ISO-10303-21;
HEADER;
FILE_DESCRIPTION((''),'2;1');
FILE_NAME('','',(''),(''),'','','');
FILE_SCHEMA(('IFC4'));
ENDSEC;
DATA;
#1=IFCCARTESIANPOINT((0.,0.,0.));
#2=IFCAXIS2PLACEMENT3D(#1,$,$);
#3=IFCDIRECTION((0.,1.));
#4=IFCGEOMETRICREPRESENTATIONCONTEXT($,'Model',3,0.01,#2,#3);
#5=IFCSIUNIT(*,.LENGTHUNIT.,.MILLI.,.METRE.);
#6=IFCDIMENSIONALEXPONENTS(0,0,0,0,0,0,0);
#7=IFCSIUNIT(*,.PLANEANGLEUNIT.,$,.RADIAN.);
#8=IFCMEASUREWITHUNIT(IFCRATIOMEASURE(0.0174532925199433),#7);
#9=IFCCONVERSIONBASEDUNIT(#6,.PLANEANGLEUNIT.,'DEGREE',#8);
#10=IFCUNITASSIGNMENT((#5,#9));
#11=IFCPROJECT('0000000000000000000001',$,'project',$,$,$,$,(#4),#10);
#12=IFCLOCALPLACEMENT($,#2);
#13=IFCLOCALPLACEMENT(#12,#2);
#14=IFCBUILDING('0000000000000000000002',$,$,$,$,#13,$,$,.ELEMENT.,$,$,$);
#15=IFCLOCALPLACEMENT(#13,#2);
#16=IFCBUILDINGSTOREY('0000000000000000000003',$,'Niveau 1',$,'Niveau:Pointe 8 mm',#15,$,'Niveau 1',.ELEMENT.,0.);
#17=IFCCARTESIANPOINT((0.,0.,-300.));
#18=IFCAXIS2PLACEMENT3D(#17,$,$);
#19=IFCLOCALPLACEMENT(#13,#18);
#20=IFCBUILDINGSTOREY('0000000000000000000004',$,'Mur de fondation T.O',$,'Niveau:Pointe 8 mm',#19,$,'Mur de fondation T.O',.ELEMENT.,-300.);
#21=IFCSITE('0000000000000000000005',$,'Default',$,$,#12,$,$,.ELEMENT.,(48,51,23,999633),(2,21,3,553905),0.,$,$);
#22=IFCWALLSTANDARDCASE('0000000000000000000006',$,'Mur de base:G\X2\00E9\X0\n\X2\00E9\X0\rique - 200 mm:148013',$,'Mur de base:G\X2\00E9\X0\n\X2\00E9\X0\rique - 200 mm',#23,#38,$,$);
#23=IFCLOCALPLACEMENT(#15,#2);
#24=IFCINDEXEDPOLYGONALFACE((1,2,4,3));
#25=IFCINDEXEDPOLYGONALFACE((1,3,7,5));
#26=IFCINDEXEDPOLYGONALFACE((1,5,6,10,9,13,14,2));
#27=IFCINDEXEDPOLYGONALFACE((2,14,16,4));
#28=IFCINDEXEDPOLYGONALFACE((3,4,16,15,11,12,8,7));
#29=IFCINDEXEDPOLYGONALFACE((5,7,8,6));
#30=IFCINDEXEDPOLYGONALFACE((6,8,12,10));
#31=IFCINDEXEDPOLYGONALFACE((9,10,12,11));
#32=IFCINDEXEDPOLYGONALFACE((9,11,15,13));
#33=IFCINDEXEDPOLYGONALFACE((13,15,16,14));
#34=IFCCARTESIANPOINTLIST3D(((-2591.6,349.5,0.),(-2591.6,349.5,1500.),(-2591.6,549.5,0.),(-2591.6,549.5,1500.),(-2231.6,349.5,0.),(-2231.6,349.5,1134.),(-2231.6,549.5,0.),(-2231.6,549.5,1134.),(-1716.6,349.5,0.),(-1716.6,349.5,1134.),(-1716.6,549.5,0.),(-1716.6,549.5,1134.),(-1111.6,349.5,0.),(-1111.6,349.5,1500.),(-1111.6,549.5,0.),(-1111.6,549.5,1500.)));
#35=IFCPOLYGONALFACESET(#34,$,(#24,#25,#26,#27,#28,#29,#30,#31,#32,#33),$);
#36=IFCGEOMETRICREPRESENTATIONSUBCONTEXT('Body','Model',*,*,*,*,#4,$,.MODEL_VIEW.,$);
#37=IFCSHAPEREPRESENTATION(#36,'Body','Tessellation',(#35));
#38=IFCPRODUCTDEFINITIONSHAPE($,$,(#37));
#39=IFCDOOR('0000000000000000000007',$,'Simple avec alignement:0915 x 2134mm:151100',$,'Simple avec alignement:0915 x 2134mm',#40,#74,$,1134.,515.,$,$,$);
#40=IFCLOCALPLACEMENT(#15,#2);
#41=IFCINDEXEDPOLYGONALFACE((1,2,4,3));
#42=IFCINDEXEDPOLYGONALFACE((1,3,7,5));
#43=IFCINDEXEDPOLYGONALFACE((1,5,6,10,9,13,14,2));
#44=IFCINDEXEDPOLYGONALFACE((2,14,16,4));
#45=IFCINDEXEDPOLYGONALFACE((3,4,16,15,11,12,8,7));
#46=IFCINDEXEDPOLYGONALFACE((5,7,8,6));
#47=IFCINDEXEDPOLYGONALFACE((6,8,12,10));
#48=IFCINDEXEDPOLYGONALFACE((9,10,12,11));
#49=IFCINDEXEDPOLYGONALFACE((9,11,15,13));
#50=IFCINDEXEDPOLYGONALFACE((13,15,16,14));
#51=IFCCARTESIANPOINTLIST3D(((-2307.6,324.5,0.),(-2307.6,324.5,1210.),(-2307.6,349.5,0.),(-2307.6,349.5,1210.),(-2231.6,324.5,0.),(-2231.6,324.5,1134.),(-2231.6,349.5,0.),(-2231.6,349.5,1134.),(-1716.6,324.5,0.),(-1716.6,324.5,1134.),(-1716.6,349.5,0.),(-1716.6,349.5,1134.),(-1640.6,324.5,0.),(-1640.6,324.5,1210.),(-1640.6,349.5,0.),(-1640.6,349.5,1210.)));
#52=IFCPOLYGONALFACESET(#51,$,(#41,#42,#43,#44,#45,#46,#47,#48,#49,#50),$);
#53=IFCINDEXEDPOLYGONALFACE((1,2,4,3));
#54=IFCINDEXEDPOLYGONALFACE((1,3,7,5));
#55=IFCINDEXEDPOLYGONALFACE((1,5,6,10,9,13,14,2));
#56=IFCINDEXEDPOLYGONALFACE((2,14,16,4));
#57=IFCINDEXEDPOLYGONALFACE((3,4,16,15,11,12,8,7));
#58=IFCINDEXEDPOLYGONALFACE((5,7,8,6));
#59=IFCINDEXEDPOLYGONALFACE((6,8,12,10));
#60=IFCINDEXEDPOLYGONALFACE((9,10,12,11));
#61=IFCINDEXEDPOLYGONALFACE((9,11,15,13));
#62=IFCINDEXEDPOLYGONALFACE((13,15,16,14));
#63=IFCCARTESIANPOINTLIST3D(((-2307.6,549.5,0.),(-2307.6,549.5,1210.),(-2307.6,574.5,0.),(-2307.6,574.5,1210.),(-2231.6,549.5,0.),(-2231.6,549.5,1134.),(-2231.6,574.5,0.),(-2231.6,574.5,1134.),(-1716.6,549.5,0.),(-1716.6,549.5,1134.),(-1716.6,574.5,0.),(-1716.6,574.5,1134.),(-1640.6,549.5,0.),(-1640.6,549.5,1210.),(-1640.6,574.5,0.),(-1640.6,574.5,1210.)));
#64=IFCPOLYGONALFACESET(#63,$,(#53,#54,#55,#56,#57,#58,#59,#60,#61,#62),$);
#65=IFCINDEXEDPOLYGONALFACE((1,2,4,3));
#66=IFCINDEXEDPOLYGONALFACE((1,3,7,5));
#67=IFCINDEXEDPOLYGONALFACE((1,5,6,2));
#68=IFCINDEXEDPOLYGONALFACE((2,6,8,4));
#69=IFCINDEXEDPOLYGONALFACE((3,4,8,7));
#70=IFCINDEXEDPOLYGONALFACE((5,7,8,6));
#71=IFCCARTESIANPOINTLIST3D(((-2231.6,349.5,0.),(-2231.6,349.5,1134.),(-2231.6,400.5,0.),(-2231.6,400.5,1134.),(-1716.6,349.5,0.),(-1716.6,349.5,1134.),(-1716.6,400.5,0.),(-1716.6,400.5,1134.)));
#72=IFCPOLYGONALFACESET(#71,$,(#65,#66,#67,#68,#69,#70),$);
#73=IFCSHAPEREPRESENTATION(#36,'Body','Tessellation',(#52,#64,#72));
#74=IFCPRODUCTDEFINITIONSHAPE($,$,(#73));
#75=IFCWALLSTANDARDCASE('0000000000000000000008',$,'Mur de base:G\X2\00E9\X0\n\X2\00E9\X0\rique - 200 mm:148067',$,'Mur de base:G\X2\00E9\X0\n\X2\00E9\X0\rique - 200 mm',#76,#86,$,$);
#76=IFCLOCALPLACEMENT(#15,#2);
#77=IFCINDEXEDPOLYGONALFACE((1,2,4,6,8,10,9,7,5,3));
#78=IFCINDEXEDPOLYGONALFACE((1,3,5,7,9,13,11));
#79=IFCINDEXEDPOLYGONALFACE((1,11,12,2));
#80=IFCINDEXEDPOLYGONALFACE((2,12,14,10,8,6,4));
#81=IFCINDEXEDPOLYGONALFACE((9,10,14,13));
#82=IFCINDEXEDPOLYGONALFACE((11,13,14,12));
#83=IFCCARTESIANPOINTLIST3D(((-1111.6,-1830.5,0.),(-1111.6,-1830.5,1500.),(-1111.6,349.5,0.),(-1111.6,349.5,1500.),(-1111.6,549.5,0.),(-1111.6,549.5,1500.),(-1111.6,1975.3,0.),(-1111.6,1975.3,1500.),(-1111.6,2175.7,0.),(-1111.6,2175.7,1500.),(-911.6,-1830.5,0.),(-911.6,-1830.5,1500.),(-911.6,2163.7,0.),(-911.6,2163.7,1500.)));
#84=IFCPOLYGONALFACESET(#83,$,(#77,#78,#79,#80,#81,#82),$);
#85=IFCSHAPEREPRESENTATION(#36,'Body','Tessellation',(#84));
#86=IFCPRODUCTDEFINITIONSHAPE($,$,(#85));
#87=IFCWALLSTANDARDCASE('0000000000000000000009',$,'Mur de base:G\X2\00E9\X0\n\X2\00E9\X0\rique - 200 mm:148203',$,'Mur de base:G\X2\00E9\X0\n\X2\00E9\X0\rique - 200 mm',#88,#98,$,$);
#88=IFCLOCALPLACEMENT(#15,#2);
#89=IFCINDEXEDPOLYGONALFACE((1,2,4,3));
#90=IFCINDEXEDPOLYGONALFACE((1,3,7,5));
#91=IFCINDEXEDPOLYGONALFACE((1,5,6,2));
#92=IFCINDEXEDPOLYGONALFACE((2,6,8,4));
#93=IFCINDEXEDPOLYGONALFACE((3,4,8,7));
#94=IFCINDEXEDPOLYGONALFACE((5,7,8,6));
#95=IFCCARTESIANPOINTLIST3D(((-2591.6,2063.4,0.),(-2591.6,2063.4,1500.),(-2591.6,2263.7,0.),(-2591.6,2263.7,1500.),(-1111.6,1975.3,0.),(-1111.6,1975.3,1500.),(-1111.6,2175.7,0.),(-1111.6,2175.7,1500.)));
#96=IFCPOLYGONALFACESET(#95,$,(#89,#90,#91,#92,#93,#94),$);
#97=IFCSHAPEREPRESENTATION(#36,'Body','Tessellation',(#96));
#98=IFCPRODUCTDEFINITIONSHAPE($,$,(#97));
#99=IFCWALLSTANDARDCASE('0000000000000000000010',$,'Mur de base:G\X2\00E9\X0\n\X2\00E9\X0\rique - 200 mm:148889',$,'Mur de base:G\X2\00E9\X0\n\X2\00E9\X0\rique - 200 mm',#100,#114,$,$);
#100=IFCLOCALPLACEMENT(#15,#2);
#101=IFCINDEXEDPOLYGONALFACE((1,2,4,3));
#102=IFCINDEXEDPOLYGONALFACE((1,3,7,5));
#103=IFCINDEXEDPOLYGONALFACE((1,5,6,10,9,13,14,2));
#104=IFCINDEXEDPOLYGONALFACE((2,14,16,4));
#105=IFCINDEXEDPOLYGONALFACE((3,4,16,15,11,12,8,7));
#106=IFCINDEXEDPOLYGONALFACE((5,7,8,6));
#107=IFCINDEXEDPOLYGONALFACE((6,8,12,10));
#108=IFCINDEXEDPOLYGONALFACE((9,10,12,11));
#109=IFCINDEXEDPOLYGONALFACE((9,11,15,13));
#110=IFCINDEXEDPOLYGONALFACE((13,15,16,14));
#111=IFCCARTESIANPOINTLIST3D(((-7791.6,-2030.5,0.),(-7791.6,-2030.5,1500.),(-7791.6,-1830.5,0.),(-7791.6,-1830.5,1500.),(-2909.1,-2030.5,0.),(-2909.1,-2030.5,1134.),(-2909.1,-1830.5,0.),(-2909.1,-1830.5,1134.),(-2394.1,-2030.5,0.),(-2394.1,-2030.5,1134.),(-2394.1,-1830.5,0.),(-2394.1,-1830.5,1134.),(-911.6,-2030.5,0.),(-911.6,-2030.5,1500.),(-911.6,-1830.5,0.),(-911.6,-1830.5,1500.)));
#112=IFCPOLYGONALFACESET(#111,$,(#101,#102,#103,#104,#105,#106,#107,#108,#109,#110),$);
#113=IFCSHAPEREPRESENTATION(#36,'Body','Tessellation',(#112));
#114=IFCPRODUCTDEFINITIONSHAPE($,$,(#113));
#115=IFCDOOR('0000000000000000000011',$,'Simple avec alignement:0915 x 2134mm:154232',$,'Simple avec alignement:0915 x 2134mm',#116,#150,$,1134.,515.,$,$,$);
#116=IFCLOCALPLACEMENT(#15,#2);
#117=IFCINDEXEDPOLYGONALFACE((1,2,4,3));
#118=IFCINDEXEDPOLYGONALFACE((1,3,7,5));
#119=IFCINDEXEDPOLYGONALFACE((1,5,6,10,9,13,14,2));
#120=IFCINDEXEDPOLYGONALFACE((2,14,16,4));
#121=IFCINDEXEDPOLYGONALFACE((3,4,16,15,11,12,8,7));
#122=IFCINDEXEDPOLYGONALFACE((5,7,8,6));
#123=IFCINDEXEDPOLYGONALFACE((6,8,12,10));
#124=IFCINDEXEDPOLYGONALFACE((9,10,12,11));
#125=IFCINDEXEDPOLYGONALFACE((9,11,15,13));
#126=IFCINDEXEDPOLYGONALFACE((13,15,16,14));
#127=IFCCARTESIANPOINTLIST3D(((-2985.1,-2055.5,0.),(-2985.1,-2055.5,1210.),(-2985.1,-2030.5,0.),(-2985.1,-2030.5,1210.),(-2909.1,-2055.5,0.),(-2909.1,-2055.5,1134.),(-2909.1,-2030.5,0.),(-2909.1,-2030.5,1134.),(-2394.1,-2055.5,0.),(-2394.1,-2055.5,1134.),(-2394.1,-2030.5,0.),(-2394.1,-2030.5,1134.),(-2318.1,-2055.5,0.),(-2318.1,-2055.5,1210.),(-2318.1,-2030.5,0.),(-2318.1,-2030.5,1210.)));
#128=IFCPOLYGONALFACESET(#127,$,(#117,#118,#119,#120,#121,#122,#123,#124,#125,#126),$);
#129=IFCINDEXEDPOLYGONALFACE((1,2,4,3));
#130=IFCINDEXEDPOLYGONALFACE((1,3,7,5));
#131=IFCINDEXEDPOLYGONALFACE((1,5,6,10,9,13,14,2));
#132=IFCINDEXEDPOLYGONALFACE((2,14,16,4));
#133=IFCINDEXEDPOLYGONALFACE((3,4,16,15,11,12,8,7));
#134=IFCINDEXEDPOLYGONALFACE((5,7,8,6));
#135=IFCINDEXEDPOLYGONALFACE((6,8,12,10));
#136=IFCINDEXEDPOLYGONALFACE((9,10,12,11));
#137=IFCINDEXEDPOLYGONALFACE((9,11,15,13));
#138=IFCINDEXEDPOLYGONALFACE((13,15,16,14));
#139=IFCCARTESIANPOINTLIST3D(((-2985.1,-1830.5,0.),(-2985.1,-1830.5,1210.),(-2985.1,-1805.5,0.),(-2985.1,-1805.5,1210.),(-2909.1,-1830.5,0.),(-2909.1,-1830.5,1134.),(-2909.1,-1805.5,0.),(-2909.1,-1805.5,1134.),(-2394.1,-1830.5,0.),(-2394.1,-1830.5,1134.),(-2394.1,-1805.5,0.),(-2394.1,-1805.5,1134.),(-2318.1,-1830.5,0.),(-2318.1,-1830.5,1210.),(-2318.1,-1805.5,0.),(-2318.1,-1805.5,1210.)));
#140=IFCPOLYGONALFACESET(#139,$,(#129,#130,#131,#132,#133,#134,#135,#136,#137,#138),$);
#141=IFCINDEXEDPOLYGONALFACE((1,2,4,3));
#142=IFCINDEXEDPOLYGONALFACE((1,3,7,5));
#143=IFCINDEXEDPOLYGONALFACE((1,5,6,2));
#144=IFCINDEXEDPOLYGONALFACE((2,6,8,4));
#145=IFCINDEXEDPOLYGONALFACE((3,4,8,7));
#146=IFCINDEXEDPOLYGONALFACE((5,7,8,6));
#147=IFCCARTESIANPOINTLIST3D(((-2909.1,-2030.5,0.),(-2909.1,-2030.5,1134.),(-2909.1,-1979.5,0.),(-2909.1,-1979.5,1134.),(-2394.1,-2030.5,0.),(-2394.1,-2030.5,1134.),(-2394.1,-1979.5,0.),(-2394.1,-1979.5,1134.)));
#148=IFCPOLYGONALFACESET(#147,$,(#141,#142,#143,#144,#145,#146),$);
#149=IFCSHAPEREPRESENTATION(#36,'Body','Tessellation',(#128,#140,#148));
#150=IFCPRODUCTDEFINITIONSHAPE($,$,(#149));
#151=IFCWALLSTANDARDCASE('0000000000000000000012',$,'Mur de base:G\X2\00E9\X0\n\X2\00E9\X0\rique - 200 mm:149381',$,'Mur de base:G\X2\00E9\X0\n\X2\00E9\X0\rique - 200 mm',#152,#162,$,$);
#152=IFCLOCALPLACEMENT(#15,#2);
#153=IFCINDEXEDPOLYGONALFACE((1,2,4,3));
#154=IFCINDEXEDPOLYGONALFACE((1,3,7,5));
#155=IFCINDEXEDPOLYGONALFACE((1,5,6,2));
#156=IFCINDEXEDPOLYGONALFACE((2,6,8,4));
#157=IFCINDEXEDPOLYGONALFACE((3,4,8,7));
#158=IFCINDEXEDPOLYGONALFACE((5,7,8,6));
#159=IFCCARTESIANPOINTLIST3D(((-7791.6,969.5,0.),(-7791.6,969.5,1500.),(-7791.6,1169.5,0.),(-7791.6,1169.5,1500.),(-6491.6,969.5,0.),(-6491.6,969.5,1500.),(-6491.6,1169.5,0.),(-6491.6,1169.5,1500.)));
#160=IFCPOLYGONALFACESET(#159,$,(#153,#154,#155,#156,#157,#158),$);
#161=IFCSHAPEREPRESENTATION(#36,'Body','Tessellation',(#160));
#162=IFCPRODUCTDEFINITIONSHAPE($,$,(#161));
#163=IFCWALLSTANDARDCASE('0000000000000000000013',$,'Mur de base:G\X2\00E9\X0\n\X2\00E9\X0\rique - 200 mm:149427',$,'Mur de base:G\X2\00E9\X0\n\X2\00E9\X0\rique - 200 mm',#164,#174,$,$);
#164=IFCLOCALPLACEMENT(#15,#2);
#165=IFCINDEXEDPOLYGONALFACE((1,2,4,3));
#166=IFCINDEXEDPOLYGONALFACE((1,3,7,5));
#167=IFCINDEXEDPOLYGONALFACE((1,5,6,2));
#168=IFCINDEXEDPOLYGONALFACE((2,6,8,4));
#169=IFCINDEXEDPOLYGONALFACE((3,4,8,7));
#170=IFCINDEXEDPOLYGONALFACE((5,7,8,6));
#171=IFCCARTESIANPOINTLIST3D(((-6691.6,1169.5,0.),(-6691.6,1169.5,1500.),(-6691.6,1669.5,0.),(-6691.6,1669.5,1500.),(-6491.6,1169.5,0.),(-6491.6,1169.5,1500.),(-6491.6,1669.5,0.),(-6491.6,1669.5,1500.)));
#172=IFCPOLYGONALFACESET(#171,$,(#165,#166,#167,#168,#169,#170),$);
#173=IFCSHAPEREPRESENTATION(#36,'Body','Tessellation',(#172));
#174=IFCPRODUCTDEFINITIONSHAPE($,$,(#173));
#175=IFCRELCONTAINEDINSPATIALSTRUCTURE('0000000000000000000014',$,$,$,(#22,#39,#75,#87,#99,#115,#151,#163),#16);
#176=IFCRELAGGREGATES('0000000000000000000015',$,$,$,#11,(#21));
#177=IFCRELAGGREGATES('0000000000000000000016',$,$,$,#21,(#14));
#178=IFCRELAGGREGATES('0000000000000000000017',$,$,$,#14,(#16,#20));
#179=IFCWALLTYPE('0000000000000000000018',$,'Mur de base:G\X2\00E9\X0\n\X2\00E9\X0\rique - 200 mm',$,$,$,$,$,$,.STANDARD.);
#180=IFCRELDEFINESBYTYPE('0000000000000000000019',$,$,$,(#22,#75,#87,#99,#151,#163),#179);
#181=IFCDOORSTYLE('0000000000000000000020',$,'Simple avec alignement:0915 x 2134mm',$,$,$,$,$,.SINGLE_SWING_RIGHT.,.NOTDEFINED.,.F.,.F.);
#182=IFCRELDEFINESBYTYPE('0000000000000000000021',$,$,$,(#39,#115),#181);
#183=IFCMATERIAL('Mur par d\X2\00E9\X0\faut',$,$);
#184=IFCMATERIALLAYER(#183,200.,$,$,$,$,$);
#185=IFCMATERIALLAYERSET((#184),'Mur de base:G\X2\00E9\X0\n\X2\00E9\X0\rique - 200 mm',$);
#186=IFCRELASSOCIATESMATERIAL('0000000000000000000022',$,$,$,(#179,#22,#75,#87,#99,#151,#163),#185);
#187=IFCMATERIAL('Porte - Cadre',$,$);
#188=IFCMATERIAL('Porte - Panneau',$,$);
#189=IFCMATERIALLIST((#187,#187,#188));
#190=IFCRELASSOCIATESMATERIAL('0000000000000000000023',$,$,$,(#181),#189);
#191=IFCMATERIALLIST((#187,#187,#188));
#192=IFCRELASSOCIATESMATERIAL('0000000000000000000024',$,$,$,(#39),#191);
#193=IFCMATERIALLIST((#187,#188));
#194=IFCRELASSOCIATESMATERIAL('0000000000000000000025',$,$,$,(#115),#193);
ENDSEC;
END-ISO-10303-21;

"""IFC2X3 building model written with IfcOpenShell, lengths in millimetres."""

from ifc_helpers import new_model, entity, si_unit, converted_unit, direction, frame, frame_2d, origin, place, context, subcontext, project, spatial, polyline, rectangle, outline, extrude, source, transform, mapped, material, material_list, layer, layer_set, layer_usage, type_object, type_shapes, element, fill, save


model = new_model("IFC2X3")

# Units and contexts
model_context = context("Model", 3, precision=0.01, world=origin(), true_north=direction((0.0, 1.0)))
body_context = subcontext(model_context, "Body", "Model", "MODEL_VIEW")
ifc_project = project(units=[si_unit("LENGTHUNIT", "METRE", prefix="MILLI"), converted_unit("PLANEANGLEUNIT", "DEGREE", entity("IfcRatioMeasure", 0.0174532925199433), si_unit("PLANEANGLEUNIT", "RADIAN"), dimensions=[0, 0, 0, 0, 0, 0, 0])], contexts=[model_context])

# Site, building, storey
site_placement = place(None, origin())
site = spatial("IfcSite", under=ifc_project, at=site_placement, Name="Default", CompositionType="ELEMENT", RefLatitude=(48, 51, 23, 999633), RefLongitude=(2, 21, 3, 553905), RefElevation=0.0)
building_placement = place(site_placement, origin())
building = spatial("IfcBuilding", under=site, at=building_placement, CompositionType="ELEMENT")
storey_1_placement = place(building_placement, origin())
storey_1 = spatial("IfcBuildingStorey", under=building, at=storey_1_placement, Name="Niveau 1", ObjectType="Niveau:Pointe 8 mm", LongName="Niveau 1", CompositionType="ELEMENT", Elevation=0.0)

# Shared definitions
ifc_material_1 = material(Name="Mur par défaut")
ifc_layer_1 = layer(ifc_material_1, 200.0)
ifc_layer_set_1 = layer_set([ifc_layer_1], Name="Mur de base:Générique - 200 mm")
wall_type = type_object("IfcWallType", Name="Mur de base:Générique - 200 mm", PredefinedType="STANDARD", material=ifc_layer_set_1)
ifc_material_2 = material(Name="Porte - Cadre")
ifc_material_3 = material(Name="Porte - Panneau")
ifc_material_list_1 = material_list([ifc_material_2, ifc_material_2, ifc_material_3])
door_style = type_object("IfcDoorStyle", Name="Simple avec alignement:0915 x 2134mm", ConstructionType="NOTDEFINED", OperationType="SINGLE_SWING_RIGHT", ParameterTakesPrecedence=False, Sizeable=False, material=ifc_material_list_1)
shared_shape_1 = source(origin(), body_context, "Body", "SweptSolid", [
    extrude(outline(polyline([(-333.5, -624.0), (333.5, -624.0), (333.5, 586.0), (257.5, 586.0), (257.5, -548.0), (-257.5, -548.0), (-257.5, 586.0), (-333.5, 586.0), (-333.5, -624.0)])), frame((257.5, 200.0, 586.0), z_axis=(0.0, 1.0, 0.0), x_axis=(1.0, 0.0, 0.0)), (0.0, 0.0, 1.0), 25.0),
    extrude(outline(polyline([(-624.0, -333.5), (586.0, -333.5), (586.0, -257.5), (-548.0, -257.5), (-548.0, 257.5), (586.0, 257.5), (586.0, 333.5), (-624.0, 333.5), (-624.0, -333.5)])), frame((257.5, -25.0, 586.0), z_axis=(0.0, 1.0, 0.0), x_axis=(0.0, 0.0, -1.0)), (0.0, 0.0, 1.0), 25.0),
    extrude(rectangle(XDim=51.0, YDim=515.0, at=frame_2d((0.0, 0.0), x_axis=(1.0, 0.0))), frame((257.5, 174.5, 0.0), z_axis=(0.0, 0.0, 1.0), x_axis=(0.0, 1.0, 0.0)), (0.0, 0.0, 1.0), 1134.0),
])
type_shapes(door_style, [shared_shape_1])

# Shared definitions
storey_2_placement = place(building_placement, frame((0.0, 0.0, -300.0)))
storey_2 = spatial("IfcBuildingStorey", under=building, at=storey_2_placement, Name="Mur de fondation T.O", ObjectType="Niveau:Pointe 8 mm", LongName="Mur de fondation T.O", CompositionType="ELEMENT", Elevation=-300.0)

# Wall, opening, door
ifc_layer_usage_1 = layer_usage(ifc_layer_set_1, "AXIS2", "NEGATIVE", 100.0)
wall_1_placement = place(storey_1_placement, frame((-2591.6, 449.5, 0.0)))
wall_1 = element("IfcWallStandardCase", 1, at=wall_1_placement, inside=storey_1, type_object=wall_type, material=ifc_layer_usage_1, Name="Mur de base:Générique - 200 mm:148013", ObjectType="Mur de base:Générique - 200 mm", context=body_context, shape_type="SweptSolid", body=[
    extrude(rectangle(XDim=1480.0, YDim=200.0, at=frame_2d((740.0, 0.0), x_axis=(-1.0, 0.0))), origin(), (0.0, 0.0, 1.0), 1500.0),
])
opening_1_placement = place(wall_1_placement, frame((875.0, 100.0, 0.0)))
opening_1 = element("IfcOpeningElement", 2, at=opening_1_placement, cuts=wall_1, ObjectType="Opening", context=body_context, shape_type="SweptSolid", body=[
    extrude(rectangle(XDim=515.0, YDim=1134.0, at=frame_2d((567.0, 257.5), x_axis=(0.0, 1.0))), frame((0.0, 0.0, 0.0), z_axis=(0.0, -1.0, 0.0), x_axis=(0.0, 0.0, 1.0)), (0.0, 0.0, 1.0), 200.0),
])
ifc_material_list_2 = material_list([ifc_material_2, ifc_material_2, ifc_material_3])
door_1_placement = place(opening_1_placement, frame((0.0, 0.0, 0.0), z_axis=(0.0, 0.0, 1.0), x_axis=(-1.0, 0.0, 0.0)))
door_1 = element("IfcDoor", 3, at=door_1_placement, inside=storey_1, type_object=door_style, material=ifc_material_list_2, Name="Simple avec alignement:0915 x 2134mm:151100", ObjectType="Simple avec alignement:0915 x 2134mm", OverallHeight=1134.0, OverallWidth=515.0, context=body_context, shape_type="MappedRepresentation", body=[
    mapped(shared_shape_1, transform((0.0, 0.0, 0.0), scale=1.0)),
])
fill(opening_1, door_1)

# Walls
ifc_layer_usage_2 = layer_usage(ifc_layer_set_1, "AXIS2", "NEGATIVE", 100.0)
wall_2_placement = place(storey_1_placement, frame((-1011.6, -1830.5, 0.0), z_axis=(0.0, 0.0, 1.0), x_axis=(0.0, 1.0, 0.0)))
element("IfcWallStandardCase", 4, at=wall_2_placement, inside=storey_1, type_object=wall_type, material=ifc_layer_usage_2, Name="Mur de base:Générique - 200 mm:148067", ObjectType="Mur de base:Générique - 200 mm", context=body_context, shape_type="SweptSolid", body=[
    extrude(outline(polyline([(3994.2, -100.0), (4006.1, 100.0), (3805.8, 100.0), (2380.0, 100.0), (2180.0, 100.0), (0.0, 100.0), (0.0, -100.0), (3994.2, -100.0)])), origin(), (0.0, 0.0, 1.0), 1500.0),
])
ifc_layer_usage_3 = layer_usage(ifc_layer_set_1, "AXIS2", "NEGATIVE", 100.0)
wall_3_placement = place(storey_1_placement, frame((-1105.7, 2075.1, 0.0), z_axis=(0.0, 0.0, 1.0), x_axis=(-0.998233, 0.059419, 0.0)))
element("IfcWallStandardCase", 5, at=wall_3_placement, inside=storey_1, type_object=wall_type, material=ifc_layer_usage_3, Name="Mur de base:Générique - 200 mm:148203", ObjectType="Mur de base:Générique - 200 mm", context=body_context, shape_type="SweptSolid", body=[
    extrude(outline(polyline([(1494.5, -100.0), (1482.6, 100.0), (0.0, 100.0), (11.9, -100.0), (1494.5, -100.0)])), origin(), (0.0, 0.0, 1.0), 1500.0),
])

# Wall, opening, door
ifc_layer_usage_4 = layer_usage(ifc_layer_set_1, "AXIS2", "NEGATIVE", 100.0)
wall_4_placement = place(storey_1_placement, frame((-7791.6, -1930.5, 0.0)))
wall_4 = element("IfcWallStandardCase", 6, at=wall_4_placement, inside=storey_1, type_object=wall_type, material=ifc_layer_usage_4, Name="Mur de base:Générique - 200 mm:148889", ObjectType="Mur de base:Générique - 200 mm", context=body_context, shape_type="SweptSolid", body=[
    extrude(rectangle(XDim=6880.0, YDim=200.0, at=frame_2d((3440.0, 0.0), x_axis=(-1.0, 0.0))), origin(), (0.0, 0.0, 1.0), 1500.0),
])
opening_2_placement = place(wall_4_placement, frame((5397.5, 100.0, 0.0)))
opening_2 = element("IfcOpeningElement", 7, at=opening_2_placement, cuts=wall_4, ObjectType="Opening", context=body_context, shape_type="SweptSolid", body=[
    extrude(rectangle(XDim=515.0, YDim=1134.0, at=frame_2d((567.0, 257.5), x_axis=(0.0, 1.0))), frame((0.0, 0.0, 0.0), z_axis=(0.0, -1.0, 0.0), x_axis=(0.0, 0.0, 1.0)), (0.0, 0.0, 1.0), 200.0),
])
ifc_material_list_3 = material_list([ifc_material_2, ifc_material_3])
door_2_placement = place(opening_2_placement, frame((0.0, 0.0, 0.0), z_axis=(0.0, 0.0, 1.0), x_axis=(-1.0, 0.0, 0.0)))
door_2 = element("IfcDoor", 8, at=door_2_placement, inside=storey_1, type_object=door_style, material=ifc_material_list_3, Name="Simple avec alignement:0915 x 2134mm:154232", ObjectType="Simple avec alignement:0915 x 2134mm", OverallHeight=1134.0, OverallWidth=515.0, context=body_context, shape_type="MappedRepresentation", body=[
    mapped(shared_shape_1, transform((0.0, 0.0, 0.0), scale=1.0)),
])
fill(opening_2, door_2)

# Walls
ifc_layer_usage_5 = layer_usage(ifc_layer_set_1, "AXIS2", "NEGATIVE", 100.0)
wall_5_placement = place(storey_1_placement, frame((-7791.6, 1069.5, 0.0)))
element("IfcWallStandardCase", 9, at=wall_5_placement, inside=storey_1, type_object=wall_type, material=ifc_layer_usage_5, Name="Mur de base:Générique - 200 mm:149381", ObjectType="Mur de base:Générique - 200 mm", context=body_context, shape_type="SweptSolid", body=[
    extrude(rectangle(XDim=1300.0, YDim=200.0, at=frame_2d((650.0, 0.0), x_axis=(-1.0, 0.0))), origin(), (0.0, 0.0, 1.0), 1500.0),
])
ifc_layer_usage_6 = layer_usage(ifc_layer_set_1, "AXIS2", "NEGATIVE", 100.0)
wall_6_placement = place(storey_1_placement, frame((-6591.6, 1169.5, 0.0), z_axis=(0.0, 0.0, 1.0), x_axis=(0.0, 1.0, 0.0)))
element("IfcWallStandardCase", 10, at=wall_6_placement, inside=storey_1, type_object=wall_type, material=ifc_layer_usage_6, Name="Mur de base:Générique - 200 mm:149427", ObjectType="Mur de base:Générique - 200 mm", context=body_context, shape_type="SweptSolid", body=[
    extrude(rectangle(XDim=500.0, YDim=200.0, at=frame_2d((250.0, 0.0), x_axis=(-1.0, 0.0))), origin(), (0.0, 0.0, 1.0), 1500.0),
])

save(model, "model.ifc")
